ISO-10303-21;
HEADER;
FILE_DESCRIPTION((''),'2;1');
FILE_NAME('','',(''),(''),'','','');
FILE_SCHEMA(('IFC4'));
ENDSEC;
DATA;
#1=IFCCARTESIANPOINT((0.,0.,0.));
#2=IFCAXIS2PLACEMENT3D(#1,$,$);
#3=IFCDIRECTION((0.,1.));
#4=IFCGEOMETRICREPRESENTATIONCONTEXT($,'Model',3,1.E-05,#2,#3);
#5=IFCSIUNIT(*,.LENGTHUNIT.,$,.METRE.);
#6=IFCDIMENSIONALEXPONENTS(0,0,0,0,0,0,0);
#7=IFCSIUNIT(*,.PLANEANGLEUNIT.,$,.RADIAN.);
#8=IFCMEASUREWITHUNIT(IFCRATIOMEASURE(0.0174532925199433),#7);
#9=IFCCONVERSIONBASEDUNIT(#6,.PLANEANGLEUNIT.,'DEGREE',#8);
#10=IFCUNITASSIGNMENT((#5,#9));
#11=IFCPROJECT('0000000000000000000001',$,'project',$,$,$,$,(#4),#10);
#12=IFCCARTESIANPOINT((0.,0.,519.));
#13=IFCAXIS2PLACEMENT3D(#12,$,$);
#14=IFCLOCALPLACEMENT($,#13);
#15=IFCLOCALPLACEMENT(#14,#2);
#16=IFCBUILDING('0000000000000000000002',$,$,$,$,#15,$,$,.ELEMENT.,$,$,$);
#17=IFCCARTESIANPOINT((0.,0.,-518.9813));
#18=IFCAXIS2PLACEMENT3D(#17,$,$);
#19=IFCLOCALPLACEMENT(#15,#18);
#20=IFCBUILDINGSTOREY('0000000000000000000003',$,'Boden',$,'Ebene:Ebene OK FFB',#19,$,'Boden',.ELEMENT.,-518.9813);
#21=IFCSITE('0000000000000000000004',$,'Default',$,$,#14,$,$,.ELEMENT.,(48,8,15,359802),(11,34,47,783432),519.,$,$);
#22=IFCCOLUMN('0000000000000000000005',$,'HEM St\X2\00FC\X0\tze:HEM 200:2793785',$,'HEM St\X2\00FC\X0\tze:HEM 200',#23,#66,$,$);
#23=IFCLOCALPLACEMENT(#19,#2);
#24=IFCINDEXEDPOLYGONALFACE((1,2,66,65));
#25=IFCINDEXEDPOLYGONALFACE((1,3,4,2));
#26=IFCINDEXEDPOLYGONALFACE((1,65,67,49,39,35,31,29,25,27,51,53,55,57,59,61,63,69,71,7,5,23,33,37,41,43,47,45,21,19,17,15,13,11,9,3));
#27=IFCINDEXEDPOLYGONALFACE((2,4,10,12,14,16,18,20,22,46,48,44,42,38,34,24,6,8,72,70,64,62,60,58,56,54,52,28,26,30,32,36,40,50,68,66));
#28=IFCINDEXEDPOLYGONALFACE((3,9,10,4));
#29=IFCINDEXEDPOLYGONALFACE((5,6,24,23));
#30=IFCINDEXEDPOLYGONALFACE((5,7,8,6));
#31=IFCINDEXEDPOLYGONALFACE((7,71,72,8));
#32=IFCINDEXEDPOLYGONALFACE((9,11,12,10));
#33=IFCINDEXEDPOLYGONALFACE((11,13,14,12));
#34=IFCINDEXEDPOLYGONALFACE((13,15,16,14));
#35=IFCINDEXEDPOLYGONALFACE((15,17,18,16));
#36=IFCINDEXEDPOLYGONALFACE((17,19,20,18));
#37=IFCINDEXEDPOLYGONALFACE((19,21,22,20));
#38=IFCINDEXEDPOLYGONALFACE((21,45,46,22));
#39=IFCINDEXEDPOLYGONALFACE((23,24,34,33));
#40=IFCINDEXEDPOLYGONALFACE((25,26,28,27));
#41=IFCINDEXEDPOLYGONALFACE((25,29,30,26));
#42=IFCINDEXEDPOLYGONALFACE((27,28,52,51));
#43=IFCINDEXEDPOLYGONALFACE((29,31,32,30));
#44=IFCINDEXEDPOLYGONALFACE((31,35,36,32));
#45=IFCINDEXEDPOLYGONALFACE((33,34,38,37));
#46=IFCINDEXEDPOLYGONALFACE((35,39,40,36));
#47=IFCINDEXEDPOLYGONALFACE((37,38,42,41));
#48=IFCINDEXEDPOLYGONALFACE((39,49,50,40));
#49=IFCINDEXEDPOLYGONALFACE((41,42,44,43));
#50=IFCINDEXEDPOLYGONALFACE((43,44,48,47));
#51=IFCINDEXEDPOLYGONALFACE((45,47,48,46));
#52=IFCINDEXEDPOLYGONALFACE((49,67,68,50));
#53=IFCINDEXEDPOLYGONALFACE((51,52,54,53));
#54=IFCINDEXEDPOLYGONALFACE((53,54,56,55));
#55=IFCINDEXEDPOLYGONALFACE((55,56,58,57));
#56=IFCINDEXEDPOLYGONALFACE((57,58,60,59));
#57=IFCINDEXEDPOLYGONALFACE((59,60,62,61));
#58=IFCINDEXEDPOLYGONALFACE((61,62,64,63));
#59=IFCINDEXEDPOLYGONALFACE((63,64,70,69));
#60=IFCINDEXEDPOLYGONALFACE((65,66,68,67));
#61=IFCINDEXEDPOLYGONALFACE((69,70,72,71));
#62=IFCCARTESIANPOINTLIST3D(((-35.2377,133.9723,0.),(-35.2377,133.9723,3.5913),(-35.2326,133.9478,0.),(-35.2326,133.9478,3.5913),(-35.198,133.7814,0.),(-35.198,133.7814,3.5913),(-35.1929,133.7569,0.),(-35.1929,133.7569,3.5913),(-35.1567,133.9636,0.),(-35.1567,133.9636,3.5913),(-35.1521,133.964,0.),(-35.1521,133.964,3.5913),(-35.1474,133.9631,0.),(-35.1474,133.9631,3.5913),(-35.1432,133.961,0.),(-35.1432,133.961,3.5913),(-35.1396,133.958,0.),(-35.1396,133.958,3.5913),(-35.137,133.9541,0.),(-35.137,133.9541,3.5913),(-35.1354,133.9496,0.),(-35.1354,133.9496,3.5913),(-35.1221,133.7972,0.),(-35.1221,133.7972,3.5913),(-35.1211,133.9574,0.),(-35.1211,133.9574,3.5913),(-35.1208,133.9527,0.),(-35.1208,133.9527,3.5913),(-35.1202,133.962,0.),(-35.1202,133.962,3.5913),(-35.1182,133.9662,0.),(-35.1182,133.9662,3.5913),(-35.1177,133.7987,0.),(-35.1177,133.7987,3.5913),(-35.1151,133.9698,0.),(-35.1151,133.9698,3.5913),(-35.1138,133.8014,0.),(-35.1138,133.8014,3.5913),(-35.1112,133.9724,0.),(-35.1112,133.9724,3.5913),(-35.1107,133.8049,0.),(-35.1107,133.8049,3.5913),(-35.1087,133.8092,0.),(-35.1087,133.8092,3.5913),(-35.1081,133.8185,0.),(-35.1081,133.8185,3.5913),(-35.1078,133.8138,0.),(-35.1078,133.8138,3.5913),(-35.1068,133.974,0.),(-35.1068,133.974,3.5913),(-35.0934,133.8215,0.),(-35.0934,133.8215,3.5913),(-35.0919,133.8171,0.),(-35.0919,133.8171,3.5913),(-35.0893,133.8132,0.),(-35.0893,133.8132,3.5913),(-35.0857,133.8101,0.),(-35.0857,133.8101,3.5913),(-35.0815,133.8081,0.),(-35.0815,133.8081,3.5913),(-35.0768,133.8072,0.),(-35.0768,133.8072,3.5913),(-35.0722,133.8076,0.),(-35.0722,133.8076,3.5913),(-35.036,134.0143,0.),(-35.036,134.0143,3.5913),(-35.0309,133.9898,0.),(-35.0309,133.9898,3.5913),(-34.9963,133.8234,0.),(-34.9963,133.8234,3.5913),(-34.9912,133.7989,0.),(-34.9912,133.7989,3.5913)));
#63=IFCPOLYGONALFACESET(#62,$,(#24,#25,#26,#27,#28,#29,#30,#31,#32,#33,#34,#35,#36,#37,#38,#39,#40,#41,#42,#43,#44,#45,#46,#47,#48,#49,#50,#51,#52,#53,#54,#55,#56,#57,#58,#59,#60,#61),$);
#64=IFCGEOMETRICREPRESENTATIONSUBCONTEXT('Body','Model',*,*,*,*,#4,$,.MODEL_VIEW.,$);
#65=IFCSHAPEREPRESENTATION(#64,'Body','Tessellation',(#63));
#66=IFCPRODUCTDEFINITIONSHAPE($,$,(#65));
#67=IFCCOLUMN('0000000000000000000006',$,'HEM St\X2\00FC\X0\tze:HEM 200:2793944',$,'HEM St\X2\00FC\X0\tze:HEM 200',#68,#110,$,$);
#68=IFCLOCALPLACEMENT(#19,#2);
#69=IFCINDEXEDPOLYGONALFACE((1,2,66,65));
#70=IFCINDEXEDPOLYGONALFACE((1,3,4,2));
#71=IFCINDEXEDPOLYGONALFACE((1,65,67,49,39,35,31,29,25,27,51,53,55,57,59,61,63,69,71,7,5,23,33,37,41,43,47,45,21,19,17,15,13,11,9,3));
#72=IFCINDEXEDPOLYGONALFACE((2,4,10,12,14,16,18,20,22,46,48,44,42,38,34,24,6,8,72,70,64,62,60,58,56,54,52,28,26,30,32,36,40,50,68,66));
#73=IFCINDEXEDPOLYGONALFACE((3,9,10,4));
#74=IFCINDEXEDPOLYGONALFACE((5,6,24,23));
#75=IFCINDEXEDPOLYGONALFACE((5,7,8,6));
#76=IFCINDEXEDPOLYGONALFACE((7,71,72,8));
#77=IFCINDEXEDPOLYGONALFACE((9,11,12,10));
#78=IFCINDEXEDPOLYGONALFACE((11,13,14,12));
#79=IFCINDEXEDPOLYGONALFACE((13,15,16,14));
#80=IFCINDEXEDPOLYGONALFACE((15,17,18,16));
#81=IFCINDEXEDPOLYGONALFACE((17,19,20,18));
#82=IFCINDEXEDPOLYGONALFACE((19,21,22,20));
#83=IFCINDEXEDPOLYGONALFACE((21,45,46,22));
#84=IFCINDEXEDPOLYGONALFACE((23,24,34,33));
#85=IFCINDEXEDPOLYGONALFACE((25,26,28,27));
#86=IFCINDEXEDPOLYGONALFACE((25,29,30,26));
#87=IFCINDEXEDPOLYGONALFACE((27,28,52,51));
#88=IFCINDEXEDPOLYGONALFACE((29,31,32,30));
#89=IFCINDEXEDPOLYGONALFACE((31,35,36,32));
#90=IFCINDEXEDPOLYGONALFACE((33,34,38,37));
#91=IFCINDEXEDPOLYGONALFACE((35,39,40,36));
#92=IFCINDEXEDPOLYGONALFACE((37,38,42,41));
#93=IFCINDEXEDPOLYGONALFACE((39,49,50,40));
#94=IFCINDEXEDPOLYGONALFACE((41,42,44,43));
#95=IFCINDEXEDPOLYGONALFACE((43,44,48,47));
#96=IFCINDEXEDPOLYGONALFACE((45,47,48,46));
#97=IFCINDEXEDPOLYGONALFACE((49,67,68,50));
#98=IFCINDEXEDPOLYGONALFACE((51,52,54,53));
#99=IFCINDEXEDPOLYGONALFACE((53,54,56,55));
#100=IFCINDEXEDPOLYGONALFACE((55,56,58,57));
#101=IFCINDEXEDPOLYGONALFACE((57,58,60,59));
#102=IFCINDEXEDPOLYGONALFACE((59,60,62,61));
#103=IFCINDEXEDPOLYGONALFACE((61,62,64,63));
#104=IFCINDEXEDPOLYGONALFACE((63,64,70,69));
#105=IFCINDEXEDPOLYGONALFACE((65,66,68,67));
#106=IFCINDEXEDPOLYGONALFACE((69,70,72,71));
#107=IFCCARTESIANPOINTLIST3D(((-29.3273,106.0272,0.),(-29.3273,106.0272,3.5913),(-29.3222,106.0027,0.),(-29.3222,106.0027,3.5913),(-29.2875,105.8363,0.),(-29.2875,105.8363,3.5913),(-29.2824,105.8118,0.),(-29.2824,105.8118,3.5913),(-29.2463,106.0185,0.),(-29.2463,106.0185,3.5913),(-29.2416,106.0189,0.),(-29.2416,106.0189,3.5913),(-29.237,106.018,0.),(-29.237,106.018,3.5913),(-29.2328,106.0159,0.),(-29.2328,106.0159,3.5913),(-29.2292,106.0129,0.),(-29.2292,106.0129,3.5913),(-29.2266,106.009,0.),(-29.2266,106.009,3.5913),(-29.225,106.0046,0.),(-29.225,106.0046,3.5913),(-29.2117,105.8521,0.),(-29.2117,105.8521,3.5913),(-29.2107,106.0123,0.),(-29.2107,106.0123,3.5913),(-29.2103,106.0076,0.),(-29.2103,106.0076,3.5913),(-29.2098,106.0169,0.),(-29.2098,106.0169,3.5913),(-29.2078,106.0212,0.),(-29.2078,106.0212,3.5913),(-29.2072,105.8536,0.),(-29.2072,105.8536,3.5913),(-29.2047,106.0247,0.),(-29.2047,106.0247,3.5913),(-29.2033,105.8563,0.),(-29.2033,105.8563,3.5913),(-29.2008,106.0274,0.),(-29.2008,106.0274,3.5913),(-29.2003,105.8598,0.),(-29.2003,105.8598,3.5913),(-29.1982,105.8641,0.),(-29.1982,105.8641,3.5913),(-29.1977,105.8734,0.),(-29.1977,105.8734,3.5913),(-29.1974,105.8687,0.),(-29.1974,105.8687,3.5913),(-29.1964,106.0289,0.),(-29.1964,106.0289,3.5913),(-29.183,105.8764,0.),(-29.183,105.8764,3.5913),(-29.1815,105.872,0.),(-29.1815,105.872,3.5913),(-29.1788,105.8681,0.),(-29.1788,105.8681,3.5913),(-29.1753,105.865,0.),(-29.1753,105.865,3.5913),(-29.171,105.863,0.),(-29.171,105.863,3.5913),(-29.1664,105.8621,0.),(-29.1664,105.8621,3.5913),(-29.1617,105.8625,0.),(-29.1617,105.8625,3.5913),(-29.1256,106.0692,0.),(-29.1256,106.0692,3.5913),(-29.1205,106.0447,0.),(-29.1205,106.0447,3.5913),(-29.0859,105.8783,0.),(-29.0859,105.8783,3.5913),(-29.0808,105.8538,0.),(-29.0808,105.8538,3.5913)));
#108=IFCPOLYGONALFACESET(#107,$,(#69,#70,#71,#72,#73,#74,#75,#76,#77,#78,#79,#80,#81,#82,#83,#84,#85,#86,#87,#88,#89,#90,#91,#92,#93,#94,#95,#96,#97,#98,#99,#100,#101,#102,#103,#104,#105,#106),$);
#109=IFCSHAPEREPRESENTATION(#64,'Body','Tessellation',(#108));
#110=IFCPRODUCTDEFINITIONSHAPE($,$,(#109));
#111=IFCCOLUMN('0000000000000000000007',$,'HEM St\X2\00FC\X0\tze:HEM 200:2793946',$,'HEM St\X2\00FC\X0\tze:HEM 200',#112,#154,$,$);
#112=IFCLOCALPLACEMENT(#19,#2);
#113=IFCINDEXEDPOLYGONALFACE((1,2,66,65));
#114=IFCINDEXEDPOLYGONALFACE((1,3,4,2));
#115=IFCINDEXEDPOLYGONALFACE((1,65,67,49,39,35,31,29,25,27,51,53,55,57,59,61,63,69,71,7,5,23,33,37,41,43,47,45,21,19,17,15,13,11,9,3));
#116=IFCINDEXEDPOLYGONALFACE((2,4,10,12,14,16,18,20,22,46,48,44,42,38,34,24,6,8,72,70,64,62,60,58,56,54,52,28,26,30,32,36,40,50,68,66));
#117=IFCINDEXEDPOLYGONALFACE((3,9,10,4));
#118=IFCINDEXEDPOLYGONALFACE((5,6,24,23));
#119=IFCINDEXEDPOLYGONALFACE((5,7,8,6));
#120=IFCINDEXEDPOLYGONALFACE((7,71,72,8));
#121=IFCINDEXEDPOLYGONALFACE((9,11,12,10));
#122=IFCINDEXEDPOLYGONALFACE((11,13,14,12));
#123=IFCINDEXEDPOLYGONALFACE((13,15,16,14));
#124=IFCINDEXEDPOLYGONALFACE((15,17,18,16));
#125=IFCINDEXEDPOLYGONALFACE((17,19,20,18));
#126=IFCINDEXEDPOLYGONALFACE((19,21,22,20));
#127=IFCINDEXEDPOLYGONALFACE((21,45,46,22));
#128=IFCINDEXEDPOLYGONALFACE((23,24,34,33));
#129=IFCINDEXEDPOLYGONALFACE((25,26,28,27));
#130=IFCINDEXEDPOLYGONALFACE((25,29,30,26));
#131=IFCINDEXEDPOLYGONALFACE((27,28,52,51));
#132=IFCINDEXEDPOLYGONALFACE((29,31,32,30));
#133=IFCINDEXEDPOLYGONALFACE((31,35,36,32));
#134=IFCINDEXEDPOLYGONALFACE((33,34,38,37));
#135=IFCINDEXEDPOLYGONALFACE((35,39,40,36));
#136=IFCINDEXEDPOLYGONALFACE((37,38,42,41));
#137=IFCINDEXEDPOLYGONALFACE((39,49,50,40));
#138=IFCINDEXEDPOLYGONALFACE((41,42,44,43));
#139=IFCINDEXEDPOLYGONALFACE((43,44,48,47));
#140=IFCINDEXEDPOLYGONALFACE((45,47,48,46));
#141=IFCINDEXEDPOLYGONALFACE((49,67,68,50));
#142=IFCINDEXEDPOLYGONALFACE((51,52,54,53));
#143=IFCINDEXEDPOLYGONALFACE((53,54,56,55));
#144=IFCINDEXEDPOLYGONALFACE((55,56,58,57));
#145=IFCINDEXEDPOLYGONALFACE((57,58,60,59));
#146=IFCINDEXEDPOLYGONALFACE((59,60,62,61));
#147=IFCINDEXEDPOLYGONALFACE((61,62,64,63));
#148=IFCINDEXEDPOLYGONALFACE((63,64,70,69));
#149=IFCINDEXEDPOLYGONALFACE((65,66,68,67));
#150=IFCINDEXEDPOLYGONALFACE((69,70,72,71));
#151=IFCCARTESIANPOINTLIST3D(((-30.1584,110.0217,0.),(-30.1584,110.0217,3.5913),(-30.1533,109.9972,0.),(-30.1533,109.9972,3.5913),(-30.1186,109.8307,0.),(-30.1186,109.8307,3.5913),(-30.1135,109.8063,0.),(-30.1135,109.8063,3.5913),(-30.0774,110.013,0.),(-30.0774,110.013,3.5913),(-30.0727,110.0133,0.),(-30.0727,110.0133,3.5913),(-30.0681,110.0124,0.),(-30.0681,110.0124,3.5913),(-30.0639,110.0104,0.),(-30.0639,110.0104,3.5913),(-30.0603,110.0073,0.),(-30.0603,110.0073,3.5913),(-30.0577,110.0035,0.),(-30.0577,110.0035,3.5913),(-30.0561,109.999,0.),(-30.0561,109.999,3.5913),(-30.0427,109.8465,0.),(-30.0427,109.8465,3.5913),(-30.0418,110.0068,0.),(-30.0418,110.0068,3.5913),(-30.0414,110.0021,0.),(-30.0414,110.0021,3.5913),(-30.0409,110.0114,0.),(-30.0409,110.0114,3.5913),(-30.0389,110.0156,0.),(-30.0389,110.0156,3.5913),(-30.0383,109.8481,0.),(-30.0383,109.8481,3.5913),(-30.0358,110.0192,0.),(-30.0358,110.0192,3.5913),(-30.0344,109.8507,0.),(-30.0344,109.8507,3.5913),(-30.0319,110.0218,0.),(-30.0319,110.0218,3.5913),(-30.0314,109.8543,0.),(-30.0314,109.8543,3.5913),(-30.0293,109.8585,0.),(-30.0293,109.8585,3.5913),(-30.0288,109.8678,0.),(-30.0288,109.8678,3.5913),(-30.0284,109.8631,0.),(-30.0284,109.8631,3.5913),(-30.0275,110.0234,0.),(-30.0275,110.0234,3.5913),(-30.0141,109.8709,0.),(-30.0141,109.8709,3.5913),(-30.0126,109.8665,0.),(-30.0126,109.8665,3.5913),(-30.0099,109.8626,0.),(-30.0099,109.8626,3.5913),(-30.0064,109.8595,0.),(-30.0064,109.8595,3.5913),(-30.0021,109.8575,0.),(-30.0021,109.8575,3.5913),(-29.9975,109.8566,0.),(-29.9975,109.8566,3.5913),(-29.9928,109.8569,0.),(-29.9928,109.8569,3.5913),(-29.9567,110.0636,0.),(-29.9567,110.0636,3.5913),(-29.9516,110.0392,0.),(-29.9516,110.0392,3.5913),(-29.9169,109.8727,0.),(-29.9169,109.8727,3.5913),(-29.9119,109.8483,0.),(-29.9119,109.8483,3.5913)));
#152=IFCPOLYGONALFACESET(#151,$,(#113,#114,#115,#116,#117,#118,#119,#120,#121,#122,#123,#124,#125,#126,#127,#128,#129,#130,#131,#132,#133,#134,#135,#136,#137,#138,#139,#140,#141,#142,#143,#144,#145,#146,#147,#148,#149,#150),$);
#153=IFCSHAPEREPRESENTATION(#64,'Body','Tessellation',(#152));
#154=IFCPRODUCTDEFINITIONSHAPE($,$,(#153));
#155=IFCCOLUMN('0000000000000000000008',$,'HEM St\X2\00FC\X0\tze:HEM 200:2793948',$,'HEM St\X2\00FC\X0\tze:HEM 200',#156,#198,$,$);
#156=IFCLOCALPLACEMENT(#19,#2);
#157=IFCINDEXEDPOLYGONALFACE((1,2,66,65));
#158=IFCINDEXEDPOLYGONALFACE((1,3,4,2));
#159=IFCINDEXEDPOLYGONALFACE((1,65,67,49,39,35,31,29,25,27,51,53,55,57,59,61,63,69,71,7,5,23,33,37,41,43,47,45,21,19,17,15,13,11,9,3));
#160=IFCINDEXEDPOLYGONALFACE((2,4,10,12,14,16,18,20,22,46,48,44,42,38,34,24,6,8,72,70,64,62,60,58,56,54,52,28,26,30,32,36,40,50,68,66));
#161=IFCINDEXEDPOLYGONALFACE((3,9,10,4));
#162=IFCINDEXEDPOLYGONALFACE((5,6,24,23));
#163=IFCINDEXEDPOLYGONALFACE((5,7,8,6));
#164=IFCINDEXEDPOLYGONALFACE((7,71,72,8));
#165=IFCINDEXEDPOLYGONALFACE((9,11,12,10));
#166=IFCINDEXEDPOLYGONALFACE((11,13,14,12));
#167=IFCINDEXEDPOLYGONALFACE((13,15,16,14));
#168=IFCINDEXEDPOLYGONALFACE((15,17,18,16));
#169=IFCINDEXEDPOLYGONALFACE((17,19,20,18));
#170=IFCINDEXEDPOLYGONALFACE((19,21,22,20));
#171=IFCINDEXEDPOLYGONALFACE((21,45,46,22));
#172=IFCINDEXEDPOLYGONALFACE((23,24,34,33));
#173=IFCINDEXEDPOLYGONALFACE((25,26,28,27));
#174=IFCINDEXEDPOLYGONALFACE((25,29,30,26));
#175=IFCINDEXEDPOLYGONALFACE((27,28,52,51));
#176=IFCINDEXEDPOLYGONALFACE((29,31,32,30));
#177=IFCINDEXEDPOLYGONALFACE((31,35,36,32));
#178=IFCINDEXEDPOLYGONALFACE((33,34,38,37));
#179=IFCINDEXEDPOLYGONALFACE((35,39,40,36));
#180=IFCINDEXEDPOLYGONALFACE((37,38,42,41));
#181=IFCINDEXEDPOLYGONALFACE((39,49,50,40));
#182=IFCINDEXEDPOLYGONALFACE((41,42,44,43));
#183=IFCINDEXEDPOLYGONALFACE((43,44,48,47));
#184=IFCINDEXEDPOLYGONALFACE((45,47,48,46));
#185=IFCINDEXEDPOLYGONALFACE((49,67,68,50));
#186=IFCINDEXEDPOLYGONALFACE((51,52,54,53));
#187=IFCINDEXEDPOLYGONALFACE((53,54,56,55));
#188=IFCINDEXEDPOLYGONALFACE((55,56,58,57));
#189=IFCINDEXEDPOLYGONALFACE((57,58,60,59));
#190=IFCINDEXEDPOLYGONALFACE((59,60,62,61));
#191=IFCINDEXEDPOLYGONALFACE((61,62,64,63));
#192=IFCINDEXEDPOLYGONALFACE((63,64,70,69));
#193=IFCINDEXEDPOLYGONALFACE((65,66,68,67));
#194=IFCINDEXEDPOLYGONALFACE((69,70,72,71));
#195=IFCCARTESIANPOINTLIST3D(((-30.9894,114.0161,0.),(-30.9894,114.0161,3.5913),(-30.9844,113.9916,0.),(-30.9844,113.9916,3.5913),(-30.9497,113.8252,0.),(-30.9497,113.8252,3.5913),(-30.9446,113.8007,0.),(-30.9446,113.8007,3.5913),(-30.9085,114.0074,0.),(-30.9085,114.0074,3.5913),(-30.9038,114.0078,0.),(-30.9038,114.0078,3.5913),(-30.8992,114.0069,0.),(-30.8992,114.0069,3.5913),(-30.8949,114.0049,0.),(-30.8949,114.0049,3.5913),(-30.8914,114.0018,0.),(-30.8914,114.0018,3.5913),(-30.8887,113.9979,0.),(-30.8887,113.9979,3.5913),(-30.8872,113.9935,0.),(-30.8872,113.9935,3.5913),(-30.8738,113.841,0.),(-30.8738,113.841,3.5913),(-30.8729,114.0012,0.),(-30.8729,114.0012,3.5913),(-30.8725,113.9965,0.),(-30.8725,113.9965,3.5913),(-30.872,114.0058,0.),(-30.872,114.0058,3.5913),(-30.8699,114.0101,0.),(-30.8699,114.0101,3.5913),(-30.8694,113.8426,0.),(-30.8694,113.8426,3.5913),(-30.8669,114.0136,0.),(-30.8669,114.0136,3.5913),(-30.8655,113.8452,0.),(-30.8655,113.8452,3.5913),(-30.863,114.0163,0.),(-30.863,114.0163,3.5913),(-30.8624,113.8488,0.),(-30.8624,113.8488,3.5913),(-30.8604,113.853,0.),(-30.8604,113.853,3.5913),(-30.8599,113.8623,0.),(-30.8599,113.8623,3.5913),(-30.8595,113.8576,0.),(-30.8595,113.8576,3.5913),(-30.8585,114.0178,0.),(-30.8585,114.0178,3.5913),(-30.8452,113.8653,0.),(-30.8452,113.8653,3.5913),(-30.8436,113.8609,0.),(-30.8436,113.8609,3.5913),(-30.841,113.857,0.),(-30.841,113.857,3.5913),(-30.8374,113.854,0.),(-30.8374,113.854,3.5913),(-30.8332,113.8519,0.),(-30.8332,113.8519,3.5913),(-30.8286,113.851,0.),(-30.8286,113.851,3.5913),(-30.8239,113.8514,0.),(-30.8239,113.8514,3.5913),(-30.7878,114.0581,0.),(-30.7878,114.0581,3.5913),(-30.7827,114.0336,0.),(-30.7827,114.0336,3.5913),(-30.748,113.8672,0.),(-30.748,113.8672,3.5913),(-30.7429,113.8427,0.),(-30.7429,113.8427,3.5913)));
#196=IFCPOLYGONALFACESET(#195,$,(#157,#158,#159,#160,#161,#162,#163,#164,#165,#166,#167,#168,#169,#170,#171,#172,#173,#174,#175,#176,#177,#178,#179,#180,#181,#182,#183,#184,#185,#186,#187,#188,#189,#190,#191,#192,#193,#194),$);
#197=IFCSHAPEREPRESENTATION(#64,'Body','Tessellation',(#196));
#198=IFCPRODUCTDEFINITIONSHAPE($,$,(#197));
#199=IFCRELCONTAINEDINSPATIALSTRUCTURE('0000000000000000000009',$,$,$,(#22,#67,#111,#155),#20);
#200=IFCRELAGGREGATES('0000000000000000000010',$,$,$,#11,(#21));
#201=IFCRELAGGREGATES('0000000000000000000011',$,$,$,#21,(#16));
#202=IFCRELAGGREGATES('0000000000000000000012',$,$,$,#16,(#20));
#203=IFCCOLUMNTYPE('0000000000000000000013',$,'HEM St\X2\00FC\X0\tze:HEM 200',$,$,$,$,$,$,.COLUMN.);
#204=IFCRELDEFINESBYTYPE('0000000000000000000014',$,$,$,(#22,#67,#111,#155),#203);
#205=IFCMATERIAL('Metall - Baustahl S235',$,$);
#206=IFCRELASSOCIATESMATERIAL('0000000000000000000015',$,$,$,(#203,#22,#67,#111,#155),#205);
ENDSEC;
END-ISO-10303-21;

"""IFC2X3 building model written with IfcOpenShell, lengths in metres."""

from ifc_helpers import new_model, entity, si_unit, converted_unit, direction, frame, frame_2d, origin, place, context, subcontext, project, spatial, polyline, circle_curve, parameter, trimmed, segment, composite_curve, outline, extrude, source, transform, mapped, material, type_object, type_shapes, element, save


model = new_model("IFC2X3")

# Units and contexts
model_context = context("Model", 3, precision=1e-05, world=origin(), true_north=direction((0.0, 1.0)))
body_context = subcontext(model_context, "Body", "Model", "MODEL_VIEW")
ifc_project = project(units=[si_unit("LENGTHUNIT", "METRE"), converted_unit("PLANEANGLEUNIT", "DEGREE", entity("IfcRatioMeasure", 0.0174532925199433), si_unit("PLANEANGLEUNIT", "RADIAN"), dimensions=[0, 0, 0, 0, 0, 0, 0])], contexts=[model_context])

# Site, building, storey
site_placement = place(None, frame((0.0, 0.0, 519.0)))
site = spatial("IfcSite", under=ifc_project, at=site_placement, Name="Default", CompositionType="ELEMENT", RefLatitude=(48, 8, 15, 359802), RefLongitude=(11, 34, 47, 783432), RefElevation=519.0)
building_placement = place(site_placement, origin())
building = spatial("IfcBuilding", under=site, at=building_placement, CompositionType="ELEMENT")
storey_placement = place(building_placement, frame((0.0, 0.0, -518.9813)))
storey = spatial("IfcBuildingStorey", under=building, at=storey_placement, Name="Boden", ObjectType="Ebene:Ebene OK FFB", LongName="Boden", CompositionType="ELEMENT", Elevation=-518.9813)

# Columns
ifc_material = material(Name="Metall - Baustahl S235")
column_type = type_object("IfcColumnType", Name="HEM Stütze:HEM 200", PredefinedType="COLUMN", material=ifc_material)
shared_shape = source(origin(), body_context, "Body", "SweptSolid", [
    extrude(outline(composite_curve([segment(polyline([(0.085, -0.103), (0.11, -0.103)]), True, "CONTINUOUS"), segment(polyline([(0.11, -0.103), (0.11, 0.103)]), True, "CONTINUOUS"), segment(polyline([(0.11, 0.103), (0.085, 0.103)]), True, "CONTINUOUS"), segment(polyline([(0.085, 0.103), (0.085, 0.0255)]), True, "CONTINUOUS"), segment(trimmed(circle_curve(frame_2d((0.067, 0.0255), x_axis=(1.0, 0.0)), 0.018), [parameter(270.0)], [parameter(0.0)], True, "PARAMETER"), False, "CONTINUOUS"), segment(polyline([(0.067, 0.0075), (-0.067, 0.0075)]), True, "CONTINUOUS"), segment(trimmed(circle_curve(frame_2d((-0.067, 0.0255), x_axis=(0.0, -1.0)), 0.018), [parameter(270.0)], [parameter(0.0)], True, "PARAMETER"), False, "CONTINUOUS"), segment(polyline([(-0.085, 0.0255), (-0.085, 0.103)]), True, "CONTINUOUS"), segment(polyline([(-0.085, 0.103), (-0.11, 0.103)]), True, "CONTINUOUS"), segment(polyline([(-0.11, 0.103), (-0.11, -0.103)]), True, "CONTINUOUS"), segment(polyline([(-0.11, -0.103), (-0.085, -0.103)]), True, "CONTINUOUS"), segment(polyline([(-0.085, -0.103), (-0.085, -0.0255)]), True, "CONTINUOUS"), segment(trimmed(circle_curve(frame_2d((-0.067, -0.0255), x_axis=(-1.0, 0.0)), 0.018), [parameter(270.0)], [parameter(0.0)], True, "PARAMETER"), False, "CONTINUOUS"), segment(polyline([(-0.067, -0.0075), (0.067, -0.0075)]), True, "CONTINUOUS"), segment(trimmed(circle_curve(frame_2d((0.067, -0.0255), x_axis=(0.0, 1.0)), 0.018), [parameter(270.0)], [parameter(0.0)], True, "PARAMETER"), False, "CONTINUOUS"), segment(polyline([(0.085, -0.0255), (0.085, -0.103)]), True, "CONTINUOUS")], self_intersect=False)), frame((0.0, 0.0, -518.9813), z_axis=(0.0, 0.0, 1.0), x_axis=(0.0, -1.0, 0.0)), (0.0, 0.0, 1.0), 3.5913),
])
type_shapes(column_type, [shared_shape])
for number, where, z_axis, x_axis, name in (
    (1, (-35.1144, 133.8856, 518.9813), (0.0, 0.0, 1.0), (0.979008, 0.20382, 0.0), "HEM Stütze:HEM 200:2793785"),
    (2, (-29.204, 105.9405, 518.9813), (0.0, 0.0, 1.0), (0.979008, 0.20382, 0.0), "HEM Stütze:HEM 200:2793944"),
    (3, (-30.0351, 109.935, 518.9813), (0.0, 0.0, 1.0), (0.979008, 0.20382, 0.0), "HEM Stütze:HEM 200:2793946"),
    (4, (-30.8662, 113.9294, 518.9813), (0.0, 0.0, 1.0), (0.979008, 0.20382, 0.0), "HEM Stütze:HEM 200:2793948"),
):
    element("IfcColumn", number, at=place(storey_placement, frame(where, z_axis=z_axis, x_axis=x_axis)), inside=storey, type_object=column_type, material=ifc_material, Name=name, ObjectType="HEM Stütze:HEM 200", context=body_context, shape_type="MappedRepresentation", body=[
        mapped(shared_shape, transform((0.0, 0.0, 0.0), scale=1.0)),
    ])

save(model, "model.ifc")
